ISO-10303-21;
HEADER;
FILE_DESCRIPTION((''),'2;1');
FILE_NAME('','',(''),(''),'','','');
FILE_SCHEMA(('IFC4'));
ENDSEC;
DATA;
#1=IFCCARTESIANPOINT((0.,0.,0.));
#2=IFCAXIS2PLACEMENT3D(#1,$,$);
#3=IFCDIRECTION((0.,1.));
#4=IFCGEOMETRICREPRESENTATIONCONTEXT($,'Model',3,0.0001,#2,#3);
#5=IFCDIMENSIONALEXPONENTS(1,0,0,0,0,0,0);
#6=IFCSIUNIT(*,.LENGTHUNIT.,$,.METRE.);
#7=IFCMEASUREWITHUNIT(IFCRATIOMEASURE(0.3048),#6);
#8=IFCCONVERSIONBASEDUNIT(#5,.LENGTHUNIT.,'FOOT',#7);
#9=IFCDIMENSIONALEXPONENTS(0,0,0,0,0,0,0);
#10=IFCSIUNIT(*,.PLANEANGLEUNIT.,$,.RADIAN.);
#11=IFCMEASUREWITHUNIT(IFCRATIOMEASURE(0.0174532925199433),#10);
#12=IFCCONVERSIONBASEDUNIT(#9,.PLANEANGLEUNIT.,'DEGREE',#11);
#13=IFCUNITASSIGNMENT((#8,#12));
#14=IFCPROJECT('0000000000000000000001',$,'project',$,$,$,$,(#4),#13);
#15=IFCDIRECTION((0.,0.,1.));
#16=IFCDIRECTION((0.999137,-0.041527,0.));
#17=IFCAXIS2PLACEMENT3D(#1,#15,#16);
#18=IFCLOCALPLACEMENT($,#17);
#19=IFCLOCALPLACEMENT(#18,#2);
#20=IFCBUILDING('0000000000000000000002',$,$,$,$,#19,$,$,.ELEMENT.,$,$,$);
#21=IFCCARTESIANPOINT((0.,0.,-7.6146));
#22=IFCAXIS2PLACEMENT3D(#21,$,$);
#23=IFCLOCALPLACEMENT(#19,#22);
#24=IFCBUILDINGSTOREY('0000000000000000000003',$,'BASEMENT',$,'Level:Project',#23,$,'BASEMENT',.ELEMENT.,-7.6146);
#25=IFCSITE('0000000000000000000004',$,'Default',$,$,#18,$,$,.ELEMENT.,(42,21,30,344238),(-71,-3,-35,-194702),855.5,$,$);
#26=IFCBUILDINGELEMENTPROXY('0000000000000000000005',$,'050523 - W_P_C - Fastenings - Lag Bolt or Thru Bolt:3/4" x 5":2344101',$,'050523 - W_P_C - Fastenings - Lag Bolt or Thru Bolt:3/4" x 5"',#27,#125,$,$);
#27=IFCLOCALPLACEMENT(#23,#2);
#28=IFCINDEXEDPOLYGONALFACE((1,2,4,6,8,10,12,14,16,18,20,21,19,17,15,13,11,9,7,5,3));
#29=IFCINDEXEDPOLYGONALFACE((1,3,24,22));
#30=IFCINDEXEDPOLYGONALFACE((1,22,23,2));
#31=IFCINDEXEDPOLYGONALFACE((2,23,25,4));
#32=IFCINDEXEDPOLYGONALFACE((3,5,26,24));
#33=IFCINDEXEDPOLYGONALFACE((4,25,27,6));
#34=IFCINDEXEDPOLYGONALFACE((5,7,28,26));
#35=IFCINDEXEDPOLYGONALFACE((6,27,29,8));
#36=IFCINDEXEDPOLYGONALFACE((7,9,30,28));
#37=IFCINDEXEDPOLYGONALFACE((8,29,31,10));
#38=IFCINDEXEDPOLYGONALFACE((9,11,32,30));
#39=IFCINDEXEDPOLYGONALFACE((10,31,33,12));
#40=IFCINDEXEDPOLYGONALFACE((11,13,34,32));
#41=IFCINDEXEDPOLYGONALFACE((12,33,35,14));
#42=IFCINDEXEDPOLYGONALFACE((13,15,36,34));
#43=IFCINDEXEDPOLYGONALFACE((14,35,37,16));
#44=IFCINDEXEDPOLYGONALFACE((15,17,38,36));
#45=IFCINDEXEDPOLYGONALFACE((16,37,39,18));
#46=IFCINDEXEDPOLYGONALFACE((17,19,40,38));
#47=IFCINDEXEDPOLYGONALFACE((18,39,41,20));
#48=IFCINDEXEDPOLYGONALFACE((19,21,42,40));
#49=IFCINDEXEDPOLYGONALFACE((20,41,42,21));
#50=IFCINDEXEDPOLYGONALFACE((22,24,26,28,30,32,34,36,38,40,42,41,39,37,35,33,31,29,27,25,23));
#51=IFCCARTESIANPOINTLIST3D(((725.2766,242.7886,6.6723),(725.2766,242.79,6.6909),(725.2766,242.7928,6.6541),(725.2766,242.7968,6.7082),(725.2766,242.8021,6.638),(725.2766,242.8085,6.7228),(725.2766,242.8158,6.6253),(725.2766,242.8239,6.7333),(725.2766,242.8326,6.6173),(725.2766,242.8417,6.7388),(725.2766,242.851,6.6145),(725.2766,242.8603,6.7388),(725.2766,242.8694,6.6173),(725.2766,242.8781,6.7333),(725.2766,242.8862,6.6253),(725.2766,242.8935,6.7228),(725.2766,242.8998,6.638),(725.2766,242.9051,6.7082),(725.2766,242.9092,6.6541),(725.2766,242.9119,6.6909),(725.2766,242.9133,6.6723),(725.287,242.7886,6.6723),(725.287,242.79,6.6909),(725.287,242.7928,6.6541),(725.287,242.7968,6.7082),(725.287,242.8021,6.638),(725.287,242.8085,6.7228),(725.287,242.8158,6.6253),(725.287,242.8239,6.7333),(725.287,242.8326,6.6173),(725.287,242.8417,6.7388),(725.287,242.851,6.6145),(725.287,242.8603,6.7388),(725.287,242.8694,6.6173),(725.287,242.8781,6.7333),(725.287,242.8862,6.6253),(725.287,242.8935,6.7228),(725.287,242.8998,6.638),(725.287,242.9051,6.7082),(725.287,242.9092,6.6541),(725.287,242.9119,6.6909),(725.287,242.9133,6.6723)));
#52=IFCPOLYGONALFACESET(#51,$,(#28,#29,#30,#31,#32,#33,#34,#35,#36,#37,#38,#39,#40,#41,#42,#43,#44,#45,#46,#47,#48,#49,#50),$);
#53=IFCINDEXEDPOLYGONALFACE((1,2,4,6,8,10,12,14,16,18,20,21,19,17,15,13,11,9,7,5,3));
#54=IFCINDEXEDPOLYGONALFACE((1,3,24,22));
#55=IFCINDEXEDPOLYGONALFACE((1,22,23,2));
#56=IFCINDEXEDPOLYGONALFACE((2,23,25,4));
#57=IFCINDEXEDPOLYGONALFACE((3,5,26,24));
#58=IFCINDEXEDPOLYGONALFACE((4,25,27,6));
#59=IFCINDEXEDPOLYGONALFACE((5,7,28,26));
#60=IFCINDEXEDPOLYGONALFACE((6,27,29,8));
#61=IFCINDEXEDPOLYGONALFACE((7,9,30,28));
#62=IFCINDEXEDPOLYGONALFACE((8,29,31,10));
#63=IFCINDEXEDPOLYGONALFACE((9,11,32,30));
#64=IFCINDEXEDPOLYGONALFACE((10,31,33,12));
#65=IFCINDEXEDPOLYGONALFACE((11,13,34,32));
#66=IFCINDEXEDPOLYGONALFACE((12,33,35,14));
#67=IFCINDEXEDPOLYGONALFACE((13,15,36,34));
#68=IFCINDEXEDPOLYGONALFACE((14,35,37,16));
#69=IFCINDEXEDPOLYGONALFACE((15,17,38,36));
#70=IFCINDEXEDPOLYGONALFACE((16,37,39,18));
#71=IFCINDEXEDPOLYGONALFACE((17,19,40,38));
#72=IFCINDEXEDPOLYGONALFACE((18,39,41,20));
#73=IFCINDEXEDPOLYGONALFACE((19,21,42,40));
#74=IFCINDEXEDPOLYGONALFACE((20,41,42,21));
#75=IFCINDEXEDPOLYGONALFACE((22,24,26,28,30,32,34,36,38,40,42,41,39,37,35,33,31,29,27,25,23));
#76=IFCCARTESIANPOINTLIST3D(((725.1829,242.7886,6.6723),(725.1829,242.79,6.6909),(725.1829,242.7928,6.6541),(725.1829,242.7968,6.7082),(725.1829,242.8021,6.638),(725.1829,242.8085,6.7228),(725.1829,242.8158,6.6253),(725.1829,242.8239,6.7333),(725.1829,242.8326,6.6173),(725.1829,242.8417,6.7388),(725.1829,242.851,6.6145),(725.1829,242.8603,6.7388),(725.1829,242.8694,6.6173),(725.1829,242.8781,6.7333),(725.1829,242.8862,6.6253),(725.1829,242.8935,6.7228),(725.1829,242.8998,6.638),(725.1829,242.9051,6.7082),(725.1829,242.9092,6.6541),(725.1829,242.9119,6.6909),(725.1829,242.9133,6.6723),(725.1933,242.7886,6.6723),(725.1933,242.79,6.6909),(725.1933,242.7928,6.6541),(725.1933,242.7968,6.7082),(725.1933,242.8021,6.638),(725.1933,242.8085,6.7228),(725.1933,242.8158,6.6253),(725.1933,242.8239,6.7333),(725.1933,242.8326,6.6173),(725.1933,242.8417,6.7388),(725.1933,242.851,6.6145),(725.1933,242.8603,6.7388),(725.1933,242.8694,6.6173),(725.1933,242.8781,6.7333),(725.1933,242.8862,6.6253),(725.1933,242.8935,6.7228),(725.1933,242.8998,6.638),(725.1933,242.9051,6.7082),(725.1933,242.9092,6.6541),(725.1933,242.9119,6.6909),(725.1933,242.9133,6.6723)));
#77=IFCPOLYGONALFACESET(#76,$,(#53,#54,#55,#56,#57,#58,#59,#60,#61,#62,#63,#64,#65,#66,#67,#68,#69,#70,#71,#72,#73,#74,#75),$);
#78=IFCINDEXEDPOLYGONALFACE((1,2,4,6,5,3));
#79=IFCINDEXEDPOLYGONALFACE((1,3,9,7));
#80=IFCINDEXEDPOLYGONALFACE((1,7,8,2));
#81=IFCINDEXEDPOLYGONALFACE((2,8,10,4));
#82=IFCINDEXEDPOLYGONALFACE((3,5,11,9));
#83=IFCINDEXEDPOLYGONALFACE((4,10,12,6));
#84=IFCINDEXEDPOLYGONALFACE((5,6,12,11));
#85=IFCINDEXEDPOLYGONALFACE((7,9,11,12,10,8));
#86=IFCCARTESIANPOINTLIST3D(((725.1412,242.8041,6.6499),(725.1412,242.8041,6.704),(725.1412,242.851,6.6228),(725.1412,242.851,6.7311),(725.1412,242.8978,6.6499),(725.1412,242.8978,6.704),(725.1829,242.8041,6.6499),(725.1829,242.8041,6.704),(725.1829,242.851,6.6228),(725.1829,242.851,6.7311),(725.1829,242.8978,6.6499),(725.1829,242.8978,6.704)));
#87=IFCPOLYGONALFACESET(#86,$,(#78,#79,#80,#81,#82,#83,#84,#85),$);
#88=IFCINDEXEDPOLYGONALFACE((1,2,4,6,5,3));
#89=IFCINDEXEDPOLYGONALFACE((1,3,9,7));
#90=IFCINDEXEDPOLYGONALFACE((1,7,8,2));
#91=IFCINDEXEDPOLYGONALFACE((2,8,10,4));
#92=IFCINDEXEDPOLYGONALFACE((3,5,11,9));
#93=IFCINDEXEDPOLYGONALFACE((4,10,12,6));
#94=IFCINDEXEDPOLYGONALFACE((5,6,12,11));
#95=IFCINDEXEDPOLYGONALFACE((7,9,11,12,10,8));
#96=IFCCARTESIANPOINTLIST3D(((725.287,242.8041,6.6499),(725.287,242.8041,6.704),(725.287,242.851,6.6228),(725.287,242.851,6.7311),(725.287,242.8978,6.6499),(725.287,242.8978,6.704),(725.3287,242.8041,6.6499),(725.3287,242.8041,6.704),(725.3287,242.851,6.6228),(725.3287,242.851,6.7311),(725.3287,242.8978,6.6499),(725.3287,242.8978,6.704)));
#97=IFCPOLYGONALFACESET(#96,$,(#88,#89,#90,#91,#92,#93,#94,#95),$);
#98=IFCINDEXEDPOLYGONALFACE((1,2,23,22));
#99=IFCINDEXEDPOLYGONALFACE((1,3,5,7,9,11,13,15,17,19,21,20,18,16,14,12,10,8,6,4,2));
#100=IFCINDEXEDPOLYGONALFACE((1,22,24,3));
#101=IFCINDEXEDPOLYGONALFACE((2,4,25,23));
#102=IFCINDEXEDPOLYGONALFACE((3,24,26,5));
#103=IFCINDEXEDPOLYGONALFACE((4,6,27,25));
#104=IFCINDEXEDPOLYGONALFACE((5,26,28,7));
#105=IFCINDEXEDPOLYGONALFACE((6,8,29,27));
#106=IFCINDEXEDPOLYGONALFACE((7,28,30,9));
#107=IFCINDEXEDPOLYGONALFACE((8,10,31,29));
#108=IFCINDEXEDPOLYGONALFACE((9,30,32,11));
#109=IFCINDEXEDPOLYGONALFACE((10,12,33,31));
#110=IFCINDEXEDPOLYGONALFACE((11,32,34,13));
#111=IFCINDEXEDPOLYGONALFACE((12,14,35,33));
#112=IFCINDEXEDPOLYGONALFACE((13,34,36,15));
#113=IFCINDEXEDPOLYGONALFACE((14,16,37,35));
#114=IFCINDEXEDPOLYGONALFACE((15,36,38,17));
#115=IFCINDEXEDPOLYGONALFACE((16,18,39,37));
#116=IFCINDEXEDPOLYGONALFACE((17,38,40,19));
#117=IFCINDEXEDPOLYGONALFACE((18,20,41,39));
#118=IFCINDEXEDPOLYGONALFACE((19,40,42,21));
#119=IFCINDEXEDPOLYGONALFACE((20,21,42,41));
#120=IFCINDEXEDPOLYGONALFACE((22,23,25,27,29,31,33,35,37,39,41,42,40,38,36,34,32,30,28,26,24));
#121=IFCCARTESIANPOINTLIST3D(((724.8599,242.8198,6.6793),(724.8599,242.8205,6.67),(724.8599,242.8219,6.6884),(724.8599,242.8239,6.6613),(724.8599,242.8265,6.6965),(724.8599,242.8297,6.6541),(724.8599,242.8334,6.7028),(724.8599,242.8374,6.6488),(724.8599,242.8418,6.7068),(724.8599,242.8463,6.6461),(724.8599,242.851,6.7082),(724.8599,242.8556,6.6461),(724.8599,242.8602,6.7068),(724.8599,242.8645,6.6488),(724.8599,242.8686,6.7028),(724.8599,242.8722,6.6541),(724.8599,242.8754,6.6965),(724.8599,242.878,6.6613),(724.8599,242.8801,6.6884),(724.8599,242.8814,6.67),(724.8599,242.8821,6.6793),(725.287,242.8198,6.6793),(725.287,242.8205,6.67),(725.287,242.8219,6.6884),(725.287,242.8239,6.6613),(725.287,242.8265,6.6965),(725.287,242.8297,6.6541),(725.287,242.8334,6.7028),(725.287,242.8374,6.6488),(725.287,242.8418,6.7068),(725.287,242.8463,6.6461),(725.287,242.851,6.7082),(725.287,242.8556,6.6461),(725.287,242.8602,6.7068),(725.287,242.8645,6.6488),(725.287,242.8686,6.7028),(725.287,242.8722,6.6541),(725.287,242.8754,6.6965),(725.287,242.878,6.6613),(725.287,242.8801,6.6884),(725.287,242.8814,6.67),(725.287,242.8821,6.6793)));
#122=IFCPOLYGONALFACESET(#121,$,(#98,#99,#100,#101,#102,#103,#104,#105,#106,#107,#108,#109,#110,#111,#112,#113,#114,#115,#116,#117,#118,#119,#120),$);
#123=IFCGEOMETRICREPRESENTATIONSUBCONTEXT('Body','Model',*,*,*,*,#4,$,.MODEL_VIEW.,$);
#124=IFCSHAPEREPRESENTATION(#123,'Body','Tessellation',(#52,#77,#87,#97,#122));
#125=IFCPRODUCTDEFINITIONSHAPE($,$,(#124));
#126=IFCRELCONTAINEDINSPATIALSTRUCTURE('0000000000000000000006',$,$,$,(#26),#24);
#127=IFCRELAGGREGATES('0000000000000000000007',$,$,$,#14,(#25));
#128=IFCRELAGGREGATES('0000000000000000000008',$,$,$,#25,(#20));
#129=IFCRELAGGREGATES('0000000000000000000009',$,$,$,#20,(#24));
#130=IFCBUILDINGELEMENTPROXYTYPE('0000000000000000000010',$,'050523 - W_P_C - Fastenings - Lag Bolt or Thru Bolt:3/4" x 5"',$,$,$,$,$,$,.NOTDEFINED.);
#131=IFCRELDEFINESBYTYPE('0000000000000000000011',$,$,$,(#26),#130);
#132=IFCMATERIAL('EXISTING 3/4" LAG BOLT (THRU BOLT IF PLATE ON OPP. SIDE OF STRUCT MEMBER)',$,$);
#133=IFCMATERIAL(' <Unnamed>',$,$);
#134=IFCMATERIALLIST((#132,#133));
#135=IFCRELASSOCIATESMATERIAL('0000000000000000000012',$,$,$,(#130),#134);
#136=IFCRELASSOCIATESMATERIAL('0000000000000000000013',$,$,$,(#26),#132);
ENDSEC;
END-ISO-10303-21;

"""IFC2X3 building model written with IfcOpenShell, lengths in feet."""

from ifc_helpers import new_model, entity, si_unit, converted_unit, direction, frame, frame_2d, origin, place, context, subcontext, project, spatial, polyline, circle, outline, extrude, source, transform, mapped, material, material_list, type_object, type_shapes, element, save


model = new_model("IFC2X3")

# Units and contexts
model_context = context("Model", 3, precision=0.0001, world=origin(), true_north=direction((0.0, 1.0)))
body_context = subcontext(model_context, "Body", "Model", "MODEL_VIEW")
ifc_project = project(units=[converted_unit("LENGTHUNIT", "FOOT", entity("IfcRatioMeasure", 0.3048), si_unit("LENGTHUNIT", "METRE"), dimensions=[1, 0, 0, 0, 0, 0, 0]), converted_unit("PLANEANGLEUNIT", "DEGREE", entity("IfcRatioMeasure", 0.0174532925199433), si_unit("PLANEANGLEUNIT", "RADIAN"), dimensions=[0, 0, 0, 0, 0, 0, 0])], contexts=[model_context])

# Site, building, storey
site_placement = place(None, frame((0.0, 0.0, 0.0), z_axis=(0.0, 0.0, 1.0), x_axis=(0.999137, -0.041527, 0.0)))
site = spatial("IfcSite", under=ifc_project, at=site_placement, Name="Default", CompositionType="ELEMENT", RefLatitude=(42, 21, 30, 344238), RefLongitude=(-71, -3, -35, -194702), RefElevation=855.5)
building_placement = place(site_placement, origin())
building = spatial("IfcBuilding", under=site, at=building_placement, CompositionType="ELEMENT")
storey_placement = place(building_placement, frame((0.0, 0.0, -7.6146)))
storey = spatial("IfcBuildingStorey", under=building, at=storey_placement, Name="BASEMENT", ObjectType="Level:Project", LongName="BASEMENT", CompositionType="ELEMENT", Elevation=-7.6146)

# Building element proxy
ifc_material_1 = material(Name=" <Unnamed>")
ifc_material_2 = material(Name="EXISTING 3/4\" LAG BOLT (THRU BOLT IF PLATE ON OPP. SIDE OF STRUCT MEMBER)")
ifc_material_list_1 = material_list([ifc_material_2, ifc_material_1])
building_element_proxy_type_1 = type_object("IfcBuildingElementProxyType", Name="050523 - W_P_C - Fastenings - Lag Bolt or Thru Bolt:3/4\" x 5\"", PredefinedType="NOTDEFINED", material=ifc_material_list_1)
shared_shape_1 = source(origin(), body_context, "Body", "SweptSolid", [
    extrude(circle(Radius=0.0625, at=frame_2d((0.0, 0.0), x_axis=(1.0, 0.0))), frame((0.0, 0.0, 0.0), z_axis=(0.0, 0.0, 1.0), x_axis=(0.0, 1.0, 0.0)), (0.0, 0.0, 1.0), 0.0104),
    extrude(circle(Radius=0.0625, at=frame_2d((0.0, 0.0), x_axis=(1.0, 0.0))), frame((0.0, 0.0, -0.0938), z_axis=(0.0, 0.0, 1.0), x_axis=(0.0, 1.0, 0.0)), (0.0, 0.0, 1.0), 0.0104),
    extrude(outline(polyline([(-0.0271, -0.0469), (0.0271, -0.0469), (0.0541, 0.0), (0.0271, 0.0469), (-0.0271, 0.0469), (-0.0541, 0.0), (-0.0271, -0.0469)])), frame((0.0, 0.0, -0.1354), z_axis=(0.0, 0.0, 1.0), x_axis=(0.0, -1.0, 0.0)), (0.0, 0.0, 1.0), 0.0417),
    extrude(outline(polyline([(-0.0271, -0.0469), (0.0271, -0.0469), (0.0541, 0.0), (0.0271, 0.0469), (-0.0271, 0.0469), (-0.0541, 0.0), (-0.0271, -0.0469)])), frame((0.0, 0.0, 0.0104), z_axis=(0.0, 0.0, 1.0), x_axis=(0.866025, -0.5, 0.0)), (0.0, 0.0, 1.0), 0.0417),
    extrude(circle(Radius=0.0312, at=frame_2d((0.0, 0.0), x_axis=(1.0, 0.0))), frame((0.0, 0.0, -0.4167), z_axis=(0.0, 0.0, 1.0), x_axis=(0.0, -1.0, 0.0)), (0.0, 0.0, 1.0), 0.4271),
])
type_shapes(building_element_proxy_type_1, [shared_shape_1])
for number, where, z_axis, x_axis, name in (
    (1, (725.2766, 242.851, 6.677), (1.0, 0.0, 0.0), (0.0, -1.0, 0.0), "050523 - W_P_C - Fastenings - Lag Bolt or Thru Bolt:3/4\" x 5\":2344101"),
):
    element("IfcBuildingElementProxy", number, at=place(storey_placement, frame(where, z_axis=z_axis, x_axis=x_axis)), inside=storey, type_object=building_element_proxy_type_1, material=ifc_material_2, Name=name, ObjectType="050523 - W_P_C - Fastenings - Lag Bolt or Thru Bolt:3/4\" x 5\"", context=body_context, shape_type="MappedRepresentation", body=[
        mapped(shared_shape_1, transform((0.0, 0.0, 0.0), scale=1.0)),
    ])

save(model, "model.ifc")
